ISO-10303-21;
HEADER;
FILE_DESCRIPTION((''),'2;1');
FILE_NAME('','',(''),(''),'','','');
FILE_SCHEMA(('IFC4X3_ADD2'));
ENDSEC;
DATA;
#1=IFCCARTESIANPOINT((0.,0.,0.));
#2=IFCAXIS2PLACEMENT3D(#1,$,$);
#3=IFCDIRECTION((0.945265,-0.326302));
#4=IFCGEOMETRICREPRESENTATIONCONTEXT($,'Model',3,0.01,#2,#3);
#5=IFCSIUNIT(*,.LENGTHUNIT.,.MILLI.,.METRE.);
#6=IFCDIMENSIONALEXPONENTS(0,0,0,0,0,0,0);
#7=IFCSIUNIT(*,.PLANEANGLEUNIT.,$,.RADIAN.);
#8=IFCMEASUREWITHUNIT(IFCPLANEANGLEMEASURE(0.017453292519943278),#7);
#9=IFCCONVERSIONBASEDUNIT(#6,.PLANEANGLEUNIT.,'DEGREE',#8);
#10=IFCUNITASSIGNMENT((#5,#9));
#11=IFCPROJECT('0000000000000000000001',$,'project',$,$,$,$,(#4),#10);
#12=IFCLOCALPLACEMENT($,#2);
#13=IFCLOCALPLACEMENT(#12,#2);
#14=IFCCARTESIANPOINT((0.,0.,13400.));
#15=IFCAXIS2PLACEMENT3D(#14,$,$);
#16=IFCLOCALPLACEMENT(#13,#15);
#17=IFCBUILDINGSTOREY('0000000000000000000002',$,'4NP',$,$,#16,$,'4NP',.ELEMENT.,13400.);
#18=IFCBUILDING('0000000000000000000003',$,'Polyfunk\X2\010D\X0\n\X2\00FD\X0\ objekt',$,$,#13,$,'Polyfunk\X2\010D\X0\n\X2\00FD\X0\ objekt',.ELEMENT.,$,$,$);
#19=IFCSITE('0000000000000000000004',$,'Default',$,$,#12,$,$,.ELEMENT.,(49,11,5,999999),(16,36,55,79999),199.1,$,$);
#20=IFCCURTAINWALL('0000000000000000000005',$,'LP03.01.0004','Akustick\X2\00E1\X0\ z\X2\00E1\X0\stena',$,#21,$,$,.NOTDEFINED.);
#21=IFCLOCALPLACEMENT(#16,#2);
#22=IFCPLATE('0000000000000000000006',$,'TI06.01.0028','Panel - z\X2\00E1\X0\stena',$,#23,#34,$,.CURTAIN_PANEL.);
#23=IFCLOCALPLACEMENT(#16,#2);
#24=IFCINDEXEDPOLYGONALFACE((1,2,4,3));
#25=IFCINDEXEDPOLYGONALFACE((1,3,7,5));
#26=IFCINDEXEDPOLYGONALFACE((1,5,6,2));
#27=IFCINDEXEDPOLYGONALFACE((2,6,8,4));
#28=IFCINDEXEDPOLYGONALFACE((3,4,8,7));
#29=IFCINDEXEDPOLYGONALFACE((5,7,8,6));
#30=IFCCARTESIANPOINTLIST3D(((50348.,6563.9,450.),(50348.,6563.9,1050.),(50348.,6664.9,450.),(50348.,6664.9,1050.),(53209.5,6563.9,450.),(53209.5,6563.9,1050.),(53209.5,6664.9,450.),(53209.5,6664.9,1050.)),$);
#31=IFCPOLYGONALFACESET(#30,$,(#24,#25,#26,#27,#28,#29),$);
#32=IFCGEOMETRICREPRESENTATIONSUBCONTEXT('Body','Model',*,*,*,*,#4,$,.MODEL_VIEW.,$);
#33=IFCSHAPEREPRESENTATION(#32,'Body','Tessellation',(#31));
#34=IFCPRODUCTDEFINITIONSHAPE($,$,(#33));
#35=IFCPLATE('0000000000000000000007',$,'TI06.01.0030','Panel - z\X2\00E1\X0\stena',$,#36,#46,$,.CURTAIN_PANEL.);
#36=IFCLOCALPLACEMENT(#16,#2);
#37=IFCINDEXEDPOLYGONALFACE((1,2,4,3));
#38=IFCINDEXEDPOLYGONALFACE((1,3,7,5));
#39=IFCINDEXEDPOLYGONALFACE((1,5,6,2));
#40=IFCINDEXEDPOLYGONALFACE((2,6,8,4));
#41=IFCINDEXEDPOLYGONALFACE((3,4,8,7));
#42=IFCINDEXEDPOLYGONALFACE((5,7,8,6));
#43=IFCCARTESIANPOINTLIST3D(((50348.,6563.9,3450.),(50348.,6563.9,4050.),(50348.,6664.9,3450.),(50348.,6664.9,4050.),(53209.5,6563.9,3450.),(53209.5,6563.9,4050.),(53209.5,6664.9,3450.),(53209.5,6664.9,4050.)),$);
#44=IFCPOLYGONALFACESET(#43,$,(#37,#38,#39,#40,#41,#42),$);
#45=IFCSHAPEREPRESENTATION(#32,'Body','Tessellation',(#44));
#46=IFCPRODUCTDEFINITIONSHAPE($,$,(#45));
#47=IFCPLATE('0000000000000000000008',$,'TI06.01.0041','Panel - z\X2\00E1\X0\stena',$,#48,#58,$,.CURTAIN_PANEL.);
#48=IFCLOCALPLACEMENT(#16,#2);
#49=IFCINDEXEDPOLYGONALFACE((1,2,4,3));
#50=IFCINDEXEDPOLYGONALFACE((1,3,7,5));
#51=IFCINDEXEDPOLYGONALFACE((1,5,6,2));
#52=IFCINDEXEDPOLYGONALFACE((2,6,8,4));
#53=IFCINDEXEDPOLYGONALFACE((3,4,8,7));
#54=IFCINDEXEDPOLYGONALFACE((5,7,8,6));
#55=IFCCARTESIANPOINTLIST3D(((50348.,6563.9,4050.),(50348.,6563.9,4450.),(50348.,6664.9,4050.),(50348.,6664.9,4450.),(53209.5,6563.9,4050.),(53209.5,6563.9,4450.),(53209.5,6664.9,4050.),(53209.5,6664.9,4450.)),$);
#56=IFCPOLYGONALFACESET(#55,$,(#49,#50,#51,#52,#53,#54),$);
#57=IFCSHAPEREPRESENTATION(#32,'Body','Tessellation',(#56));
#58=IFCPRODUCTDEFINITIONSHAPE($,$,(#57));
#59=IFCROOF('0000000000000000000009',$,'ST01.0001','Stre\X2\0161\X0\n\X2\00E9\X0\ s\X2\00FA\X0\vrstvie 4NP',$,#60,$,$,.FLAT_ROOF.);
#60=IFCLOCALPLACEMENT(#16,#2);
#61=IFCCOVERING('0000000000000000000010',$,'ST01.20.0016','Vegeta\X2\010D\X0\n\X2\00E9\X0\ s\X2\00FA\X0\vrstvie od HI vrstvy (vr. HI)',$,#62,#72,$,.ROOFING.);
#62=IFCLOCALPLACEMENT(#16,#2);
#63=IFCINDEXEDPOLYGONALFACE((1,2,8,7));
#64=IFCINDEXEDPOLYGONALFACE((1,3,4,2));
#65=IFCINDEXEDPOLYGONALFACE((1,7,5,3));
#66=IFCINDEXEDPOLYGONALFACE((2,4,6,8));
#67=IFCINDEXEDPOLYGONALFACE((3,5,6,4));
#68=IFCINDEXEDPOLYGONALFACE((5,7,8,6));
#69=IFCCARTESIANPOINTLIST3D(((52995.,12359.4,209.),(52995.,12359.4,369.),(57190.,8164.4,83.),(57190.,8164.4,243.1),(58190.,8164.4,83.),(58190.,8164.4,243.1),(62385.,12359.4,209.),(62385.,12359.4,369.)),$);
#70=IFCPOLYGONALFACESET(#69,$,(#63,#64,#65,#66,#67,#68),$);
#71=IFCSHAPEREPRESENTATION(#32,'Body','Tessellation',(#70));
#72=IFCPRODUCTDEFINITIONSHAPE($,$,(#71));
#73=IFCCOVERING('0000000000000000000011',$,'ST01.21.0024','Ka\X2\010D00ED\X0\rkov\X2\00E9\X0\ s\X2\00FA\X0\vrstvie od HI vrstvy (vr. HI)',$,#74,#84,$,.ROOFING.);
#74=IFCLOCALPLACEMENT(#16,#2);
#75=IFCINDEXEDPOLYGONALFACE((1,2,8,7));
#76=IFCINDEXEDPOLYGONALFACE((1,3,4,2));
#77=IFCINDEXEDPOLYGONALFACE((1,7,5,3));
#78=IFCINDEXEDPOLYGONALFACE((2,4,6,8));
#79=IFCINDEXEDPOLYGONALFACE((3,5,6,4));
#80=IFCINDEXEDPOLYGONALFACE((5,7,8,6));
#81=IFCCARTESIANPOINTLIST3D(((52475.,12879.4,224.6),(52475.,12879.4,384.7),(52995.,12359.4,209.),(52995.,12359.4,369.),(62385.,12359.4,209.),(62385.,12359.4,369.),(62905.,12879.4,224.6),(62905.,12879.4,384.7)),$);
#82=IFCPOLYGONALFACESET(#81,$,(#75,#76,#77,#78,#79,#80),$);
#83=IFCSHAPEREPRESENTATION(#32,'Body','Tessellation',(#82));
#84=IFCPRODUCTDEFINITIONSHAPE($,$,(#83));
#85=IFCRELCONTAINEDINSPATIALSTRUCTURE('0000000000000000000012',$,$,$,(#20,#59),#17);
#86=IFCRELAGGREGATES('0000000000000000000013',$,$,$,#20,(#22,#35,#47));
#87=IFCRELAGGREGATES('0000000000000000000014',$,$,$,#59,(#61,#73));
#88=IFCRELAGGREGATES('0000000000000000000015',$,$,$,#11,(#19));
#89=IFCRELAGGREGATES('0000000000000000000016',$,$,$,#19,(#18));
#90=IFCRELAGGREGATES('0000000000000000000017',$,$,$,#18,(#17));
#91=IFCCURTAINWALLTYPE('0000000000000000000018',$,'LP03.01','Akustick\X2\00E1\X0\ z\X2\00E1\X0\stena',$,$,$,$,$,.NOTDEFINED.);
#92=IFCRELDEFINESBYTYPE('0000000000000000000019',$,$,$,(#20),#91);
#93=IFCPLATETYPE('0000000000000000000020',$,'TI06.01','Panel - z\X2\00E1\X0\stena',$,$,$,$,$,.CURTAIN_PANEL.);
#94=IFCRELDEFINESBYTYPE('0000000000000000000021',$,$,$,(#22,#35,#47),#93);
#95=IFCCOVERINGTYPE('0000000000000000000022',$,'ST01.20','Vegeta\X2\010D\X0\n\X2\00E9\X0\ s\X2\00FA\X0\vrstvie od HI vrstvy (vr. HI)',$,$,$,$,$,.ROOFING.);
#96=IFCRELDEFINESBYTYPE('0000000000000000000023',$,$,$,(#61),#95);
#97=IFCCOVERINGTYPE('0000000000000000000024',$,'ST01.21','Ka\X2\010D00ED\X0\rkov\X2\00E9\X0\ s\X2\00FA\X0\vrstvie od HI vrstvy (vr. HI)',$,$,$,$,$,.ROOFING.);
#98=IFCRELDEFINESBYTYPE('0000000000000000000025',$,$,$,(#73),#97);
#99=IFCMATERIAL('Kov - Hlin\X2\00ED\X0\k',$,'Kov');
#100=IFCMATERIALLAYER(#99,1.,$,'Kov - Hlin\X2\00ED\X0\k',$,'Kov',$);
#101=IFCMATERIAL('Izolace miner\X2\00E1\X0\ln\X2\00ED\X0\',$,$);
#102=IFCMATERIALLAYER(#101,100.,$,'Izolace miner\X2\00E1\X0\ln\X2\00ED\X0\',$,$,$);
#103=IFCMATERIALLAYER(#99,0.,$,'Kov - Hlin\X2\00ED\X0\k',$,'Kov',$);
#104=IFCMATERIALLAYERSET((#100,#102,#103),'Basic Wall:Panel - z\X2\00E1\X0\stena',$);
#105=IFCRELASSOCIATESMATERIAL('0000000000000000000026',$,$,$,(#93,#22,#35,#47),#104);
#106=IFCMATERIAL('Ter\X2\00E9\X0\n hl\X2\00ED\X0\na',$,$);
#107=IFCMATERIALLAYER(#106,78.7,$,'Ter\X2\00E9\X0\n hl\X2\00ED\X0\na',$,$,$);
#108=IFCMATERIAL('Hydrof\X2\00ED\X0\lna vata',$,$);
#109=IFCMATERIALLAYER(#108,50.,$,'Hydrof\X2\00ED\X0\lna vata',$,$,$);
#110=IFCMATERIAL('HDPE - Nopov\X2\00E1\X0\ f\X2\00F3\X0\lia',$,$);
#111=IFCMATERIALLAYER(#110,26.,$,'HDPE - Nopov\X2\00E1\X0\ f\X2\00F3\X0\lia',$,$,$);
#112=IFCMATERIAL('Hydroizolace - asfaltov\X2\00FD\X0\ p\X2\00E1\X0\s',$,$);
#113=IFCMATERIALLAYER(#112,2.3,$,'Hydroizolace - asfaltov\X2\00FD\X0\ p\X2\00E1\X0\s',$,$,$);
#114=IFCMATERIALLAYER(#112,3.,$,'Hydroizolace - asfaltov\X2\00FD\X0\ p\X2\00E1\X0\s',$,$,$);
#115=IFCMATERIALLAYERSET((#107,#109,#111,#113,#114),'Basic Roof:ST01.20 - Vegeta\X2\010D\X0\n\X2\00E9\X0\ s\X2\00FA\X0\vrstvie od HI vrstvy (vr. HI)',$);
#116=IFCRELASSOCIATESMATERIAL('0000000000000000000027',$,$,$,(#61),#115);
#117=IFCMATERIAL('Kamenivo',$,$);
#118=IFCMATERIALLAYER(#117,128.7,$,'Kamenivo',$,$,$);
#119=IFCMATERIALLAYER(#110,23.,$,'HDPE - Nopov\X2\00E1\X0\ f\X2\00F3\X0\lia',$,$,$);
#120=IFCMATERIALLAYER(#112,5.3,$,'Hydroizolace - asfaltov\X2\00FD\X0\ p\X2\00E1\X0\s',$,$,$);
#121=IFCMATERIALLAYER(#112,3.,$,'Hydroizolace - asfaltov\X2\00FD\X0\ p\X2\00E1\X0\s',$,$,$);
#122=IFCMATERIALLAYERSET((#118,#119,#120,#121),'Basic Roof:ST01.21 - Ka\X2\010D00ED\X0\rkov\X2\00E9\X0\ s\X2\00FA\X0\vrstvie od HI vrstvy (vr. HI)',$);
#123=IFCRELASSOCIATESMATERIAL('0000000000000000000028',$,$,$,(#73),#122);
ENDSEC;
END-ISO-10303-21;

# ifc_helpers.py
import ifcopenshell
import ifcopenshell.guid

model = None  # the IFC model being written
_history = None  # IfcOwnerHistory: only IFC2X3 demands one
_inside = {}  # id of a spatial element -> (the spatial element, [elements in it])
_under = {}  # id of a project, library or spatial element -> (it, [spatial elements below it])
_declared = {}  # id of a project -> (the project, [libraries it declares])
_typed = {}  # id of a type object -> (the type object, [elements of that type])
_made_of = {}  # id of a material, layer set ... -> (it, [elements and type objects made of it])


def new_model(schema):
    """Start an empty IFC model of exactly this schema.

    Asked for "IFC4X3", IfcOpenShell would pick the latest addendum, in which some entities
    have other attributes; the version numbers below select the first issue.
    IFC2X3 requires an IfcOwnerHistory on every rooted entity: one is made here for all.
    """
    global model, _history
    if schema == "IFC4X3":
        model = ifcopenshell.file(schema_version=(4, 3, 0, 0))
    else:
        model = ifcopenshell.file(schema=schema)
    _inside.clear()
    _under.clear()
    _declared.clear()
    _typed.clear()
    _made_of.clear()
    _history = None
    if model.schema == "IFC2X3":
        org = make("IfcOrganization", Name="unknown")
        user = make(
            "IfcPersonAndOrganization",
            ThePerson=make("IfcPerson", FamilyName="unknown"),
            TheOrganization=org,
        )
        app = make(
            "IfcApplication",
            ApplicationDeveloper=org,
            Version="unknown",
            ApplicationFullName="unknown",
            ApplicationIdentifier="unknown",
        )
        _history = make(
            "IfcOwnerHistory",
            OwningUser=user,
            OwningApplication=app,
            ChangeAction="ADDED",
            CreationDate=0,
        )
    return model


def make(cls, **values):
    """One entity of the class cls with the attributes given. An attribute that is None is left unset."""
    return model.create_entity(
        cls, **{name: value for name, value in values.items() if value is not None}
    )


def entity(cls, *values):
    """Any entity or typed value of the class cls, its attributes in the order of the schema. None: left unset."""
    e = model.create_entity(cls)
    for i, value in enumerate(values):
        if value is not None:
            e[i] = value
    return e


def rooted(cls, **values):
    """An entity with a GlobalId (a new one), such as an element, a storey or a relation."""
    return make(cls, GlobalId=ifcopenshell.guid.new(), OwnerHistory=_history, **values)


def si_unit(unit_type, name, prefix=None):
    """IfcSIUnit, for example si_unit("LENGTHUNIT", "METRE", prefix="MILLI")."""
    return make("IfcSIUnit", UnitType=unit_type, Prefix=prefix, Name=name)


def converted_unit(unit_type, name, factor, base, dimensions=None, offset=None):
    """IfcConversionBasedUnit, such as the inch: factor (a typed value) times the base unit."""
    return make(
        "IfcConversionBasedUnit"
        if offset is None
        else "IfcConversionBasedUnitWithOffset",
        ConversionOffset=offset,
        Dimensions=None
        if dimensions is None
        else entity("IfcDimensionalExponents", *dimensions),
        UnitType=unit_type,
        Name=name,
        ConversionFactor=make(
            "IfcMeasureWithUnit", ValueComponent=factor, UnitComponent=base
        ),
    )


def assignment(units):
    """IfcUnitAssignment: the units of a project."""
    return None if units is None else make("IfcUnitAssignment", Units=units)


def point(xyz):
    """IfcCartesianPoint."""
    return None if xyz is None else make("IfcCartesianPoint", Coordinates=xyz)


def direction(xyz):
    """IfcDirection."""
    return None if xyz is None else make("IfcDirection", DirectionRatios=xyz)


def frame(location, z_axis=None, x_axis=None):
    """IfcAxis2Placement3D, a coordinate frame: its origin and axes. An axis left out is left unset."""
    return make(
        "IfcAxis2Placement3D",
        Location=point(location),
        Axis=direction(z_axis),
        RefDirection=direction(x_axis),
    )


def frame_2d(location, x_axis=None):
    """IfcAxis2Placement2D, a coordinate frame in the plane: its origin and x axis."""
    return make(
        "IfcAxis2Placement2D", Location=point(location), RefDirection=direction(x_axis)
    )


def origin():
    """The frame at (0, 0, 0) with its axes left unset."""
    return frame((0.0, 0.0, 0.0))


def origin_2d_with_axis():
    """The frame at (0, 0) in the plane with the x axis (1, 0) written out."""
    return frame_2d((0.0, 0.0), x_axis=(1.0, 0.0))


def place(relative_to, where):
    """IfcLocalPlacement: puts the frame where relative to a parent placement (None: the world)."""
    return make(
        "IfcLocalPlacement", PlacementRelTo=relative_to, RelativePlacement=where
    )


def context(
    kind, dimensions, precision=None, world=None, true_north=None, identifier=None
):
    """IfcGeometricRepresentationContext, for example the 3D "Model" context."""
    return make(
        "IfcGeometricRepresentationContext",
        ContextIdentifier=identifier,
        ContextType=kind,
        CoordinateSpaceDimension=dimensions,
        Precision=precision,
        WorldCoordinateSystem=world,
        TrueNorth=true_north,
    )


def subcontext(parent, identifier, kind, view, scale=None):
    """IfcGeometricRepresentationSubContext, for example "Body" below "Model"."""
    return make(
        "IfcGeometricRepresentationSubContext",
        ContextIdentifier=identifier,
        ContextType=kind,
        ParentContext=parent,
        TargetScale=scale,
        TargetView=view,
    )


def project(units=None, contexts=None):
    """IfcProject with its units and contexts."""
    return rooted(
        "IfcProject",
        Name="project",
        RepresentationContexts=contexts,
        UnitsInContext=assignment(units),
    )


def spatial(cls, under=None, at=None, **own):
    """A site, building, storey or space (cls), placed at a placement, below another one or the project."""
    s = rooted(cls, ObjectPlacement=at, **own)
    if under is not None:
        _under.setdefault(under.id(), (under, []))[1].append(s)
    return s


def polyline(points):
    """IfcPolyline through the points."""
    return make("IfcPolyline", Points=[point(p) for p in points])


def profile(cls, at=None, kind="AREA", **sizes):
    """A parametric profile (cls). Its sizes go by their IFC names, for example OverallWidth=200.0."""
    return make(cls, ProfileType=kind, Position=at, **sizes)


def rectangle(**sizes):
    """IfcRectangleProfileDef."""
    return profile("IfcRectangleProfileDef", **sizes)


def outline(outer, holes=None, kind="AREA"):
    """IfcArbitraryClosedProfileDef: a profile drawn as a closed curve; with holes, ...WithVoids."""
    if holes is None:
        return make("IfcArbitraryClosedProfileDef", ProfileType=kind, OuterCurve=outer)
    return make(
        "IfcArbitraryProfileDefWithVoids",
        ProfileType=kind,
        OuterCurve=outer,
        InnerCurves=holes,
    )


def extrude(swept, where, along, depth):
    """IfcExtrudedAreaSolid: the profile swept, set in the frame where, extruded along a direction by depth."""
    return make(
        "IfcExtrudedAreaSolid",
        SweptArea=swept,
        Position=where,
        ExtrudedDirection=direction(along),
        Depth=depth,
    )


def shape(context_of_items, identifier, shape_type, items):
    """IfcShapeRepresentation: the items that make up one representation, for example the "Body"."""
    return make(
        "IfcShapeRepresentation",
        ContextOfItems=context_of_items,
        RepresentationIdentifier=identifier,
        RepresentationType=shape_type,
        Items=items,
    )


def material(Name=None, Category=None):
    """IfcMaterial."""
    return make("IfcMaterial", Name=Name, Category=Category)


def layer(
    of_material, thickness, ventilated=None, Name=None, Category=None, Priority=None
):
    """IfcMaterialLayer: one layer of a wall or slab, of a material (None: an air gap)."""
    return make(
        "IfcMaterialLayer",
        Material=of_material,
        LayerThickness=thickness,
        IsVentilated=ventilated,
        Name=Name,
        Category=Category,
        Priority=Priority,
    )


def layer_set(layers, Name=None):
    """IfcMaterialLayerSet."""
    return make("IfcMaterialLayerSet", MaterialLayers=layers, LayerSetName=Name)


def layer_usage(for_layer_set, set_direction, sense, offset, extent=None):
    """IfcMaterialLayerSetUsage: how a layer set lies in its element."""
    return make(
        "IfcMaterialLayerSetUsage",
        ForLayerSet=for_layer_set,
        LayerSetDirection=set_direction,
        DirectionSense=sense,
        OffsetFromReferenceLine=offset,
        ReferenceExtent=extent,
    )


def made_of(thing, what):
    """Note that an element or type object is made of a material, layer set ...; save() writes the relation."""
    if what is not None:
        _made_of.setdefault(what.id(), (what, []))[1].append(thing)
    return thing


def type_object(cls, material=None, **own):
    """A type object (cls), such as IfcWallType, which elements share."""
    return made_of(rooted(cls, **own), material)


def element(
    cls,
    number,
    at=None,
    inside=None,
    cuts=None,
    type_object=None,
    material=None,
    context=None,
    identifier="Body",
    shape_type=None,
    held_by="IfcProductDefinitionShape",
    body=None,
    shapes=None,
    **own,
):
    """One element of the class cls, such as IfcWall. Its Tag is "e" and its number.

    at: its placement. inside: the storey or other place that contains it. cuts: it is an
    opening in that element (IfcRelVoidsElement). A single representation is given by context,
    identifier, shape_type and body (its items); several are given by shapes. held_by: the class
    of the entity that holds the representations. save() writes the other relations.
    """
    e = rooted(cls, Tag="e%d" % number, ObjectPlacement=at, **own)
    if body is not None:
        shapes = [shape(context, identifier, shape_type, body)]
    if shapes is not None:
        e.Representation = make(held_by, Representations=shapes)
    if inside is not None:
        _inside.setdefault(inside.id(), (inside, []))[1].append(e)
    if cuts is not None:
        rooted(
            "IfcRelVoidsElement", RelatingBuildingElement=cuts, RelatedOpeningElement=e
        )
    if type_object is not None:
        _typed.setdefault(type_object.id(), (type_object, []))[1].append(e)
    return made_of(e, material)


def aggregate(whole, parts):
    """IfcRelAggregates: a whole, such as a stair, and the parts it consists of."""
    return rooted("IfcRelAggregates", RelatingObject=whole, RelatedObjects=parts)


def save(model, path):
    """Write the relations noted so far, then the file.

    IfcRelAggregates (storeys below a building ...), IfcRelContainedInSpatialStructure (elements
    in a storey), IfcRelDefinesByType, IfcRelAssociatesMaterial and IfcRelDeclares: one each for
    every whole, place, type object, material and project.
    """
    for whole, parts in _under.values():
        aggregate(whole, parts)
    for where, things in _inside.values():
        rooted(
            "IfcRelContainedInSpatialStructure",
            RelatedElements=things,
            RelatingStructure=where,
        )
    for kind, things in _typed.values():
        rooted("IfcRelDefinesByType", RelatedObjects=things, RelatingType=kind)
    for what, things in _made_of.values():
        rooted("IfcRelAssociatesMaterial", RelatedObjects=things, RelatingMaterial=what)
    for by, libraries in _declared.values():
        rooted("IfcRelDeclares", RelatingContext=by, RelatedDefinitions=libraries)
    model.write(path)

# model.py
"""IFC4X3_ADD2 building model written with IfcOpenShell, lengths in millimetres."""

from ifc_helpers import new_model, entity, si_unit, converted_unit, direction, frame, frame_2d, origin, origin_2d_with_axis, place, context, subcontext, project, spatial, polyline, rectangle, outline, extrude, material, layer, layer_set, layer_usage, type_object, element, aggregate, save


model = new_model("IFC4X3_ADD2")

# Units and contexts
model_context = context("Model", 3, precision=0.01, world=origin(), true_north=direction((0.945265, -0.326302)))
body_context = subcontext(model_context, "Body", "Model", "MODEL_VIEW")
ifc_project = project(units=[si_unit("LENGTHUNIT", "METRE", prefix="MILLI"), converted_unit("PLANEANGLEUNIT", "DEGREE", entity("IfcPlaneAngleMeasure", 0.017453292519943278), si_unit("PLANEANGLEUNIT", "RADIAN"), dimensions=[0, 0, 0, 0, 0, 0, 0])], contexts=[model_context])

# Site, building, storey
site_placement = place(None, origin())
site = spatial("IfcSite", under=ifc_project, at=site_placement, Name="Default", CompositionType="ELEMENT", RefLatitude=(49, 11, 5, 999999), RefLongitude=(16, 36, 55, 79999), RefElevation=199.1)
building_placement = place(site_placement, origin())
building = spatial("IfcBuilding", under=site, at=building_placement, Name="Polyfunkčný objekt", LongName="Polyfunkčný objekt", CompositionType="ELEMENT")
storey_placement = place(building_placement, frame((0.0, 0.0, 13400.0)))
storey = spatial("IfcBuildingStorey", under=building, at=storey_placement, Name="4NP", LongName="4NP", CompositionType="ELEMENT", Elevation=13400.0)

# Curtain wall
curtain_wall_type = type_object("IfcCurtainWallType", Name="LP03.01", Description="Akustická zástena", PredefinedType="NOTDEFINED")
curtain_wall_1_placement = place(storey_placement, frame((0.0, 0.0, -13400.0)))
curtain_wall_1 = element("IfcCurtainWall", 1, at=curtain_wall_1_placement, inside=storey, type_object=curtain_wall_type, Name="LP03.01.0004", Description="Akustická zástena", PredefinedType="NOTDEFINED")

# Plates
ifc_material_1 = material(Name="Kov - Hliník", Category="Kov")
ifc_layer_1 = layer(ifc_material_1, 1.0, Name="Kov - Hliník", Category="Kov")
ifc_material_2 = material(Name="Izolace minerální")
ifc_layer_2 = layer(ifc_material_2, 100.0, Name="Izolace minerální")
ifc_layer_3 = layer(ifc_material_1, 0.0, Name="Kov - Hliník", Category="Kov")
ifc_layer_set_1 = layer_set([ifc_layer_1, ifc_layer_2, ifc_layer_3], Name="Basic Wall:Panel - zástena")
ifc_layer_usage_1 = layer_usage(ifc_layer_set_1, "AXIS2", "POSITIVE", -50.5)
plate_type = type_object("IfcPlateType", Name="TI06.01", Description="Panel - zástena", PredefinedType="CURTAIN_PANEL", material=ifc_layer_set_1)
plate_1_placement = place(storey_placement, frame((50348.0, 6614.4, 450.0)))
plate_1 = element("IfcPlate", 2, at=plate_1_placement, type_object=plate_type, material=ifc_layer_usage_1, Name="TI06.01.0028", Description="Panel - zástena", PredefinedType="CURTAIN_PANEL", context=body_context, shape_type="SweptSolid", body=[
    extrude(rectangle(XDim=101.0, YDim=2861.5, at=frame_2d((0.0, 0.0), x_axis=(1.0, 0.0))), frame((1430.7, 0.0, 0.0), z_axis=(0.0, 0.0, 1.0), x_axis=(0.0, 1.0, 0.0)), (0.0, 0.0, 1.0), 600.0),
])
ifc_layer_usage_2 = layer_usage(ifc_layer_set_1, "AXIS2", "POSITIVE", -50.5)
plate_2_placement = place(storey_placement, frame((50348.0, 6614.4, 3450.0)))
plate_2 = element("IfcPlate", 3, at=plate_2_placement, type_object=plate_type, material=ifc_layer_usage_2, Name="TI06.01.0030", Description="Panel - zástena", PredefinedType="CURTAIN_PANEL", context=body_context, shape_type="SweptSolid", body=[
    extrude(rectangle(XDim=101.0, YDim=2861.5, at=frame_2d((0.0, 0.0), x_axis=(1.0, 0.0))), frame((1430.7, 0.0, 0.0), z_axis=(0.0, 0.0, 1.0), x_axis=(0.0, 1.0, 0.0)), (0.0, 0.0, 1.0), 600.0),
])
ifc_layer_usage_3 = layer_usage(ifc_layer_set_1, "AXIS2", "POSITIVE", -50.5)
plate_3_placement = place(storey_placement, frame((50348.0, 6614.4, 4050.0)))
plate_3 = element("IfcPlate", 4, at=plate_3_placement, type_object=plate_type, material=ifc_layer_usage_3, Name="TI06.01.0041", Description="Panel - zástena", PredefinedType="CURTAIN_PANEL", context=body_context, shape_type="SweptSolid", body=[
    extrude(rectangle(XDim=101.0, YDim=2861.5, at=origin_2d_with_axis()), frame((1430.7, 0.0, 0.0), z_axis=(0.0, 0.0, 1.0), x_axis=(0.0, 1.0, 0.0)), (0.0, 0.0, 1.0), 400.0),
])
aggregate(curtain_wall_1, [plate_1, plate_2, plate_3])

# Roof, coverings
roof = element("IfcRoof", 5, inside=storey, Name="ST01.0001", Description="Strešné súvrstvie 4NP", PredefinedType="FLAT_ROOF")
ifc_material_3 = material(Name="Terén hlína")
ifc_layer_4 = layer(ifc_material_3, 78.7, Name="Terén hlína")
ifc_material_4 = material(Name="Hydrofílna vata")
ifc_layer_5 = layer(ifc_material_4, 50.0, Name="Hydrofílna vata")
ifc_material_5 = material(Name="HDPE - Nopová fólia")
ifc_layer_6 = layer(ifc_material_5, 26.0, Name="HDPE - Nopová fólia")
ifc_material_6 = material(Name="Hydroizolace - asfaltový pás")
ifc_layer_7 = layer(ifc_material_6, 2.3, Name="Hydroizolace - asfaltový pás")
ifc_layer_8 = layer(ifc_material_6, 3.0, Name="Hydroizolace - asfaltový pás")
ifc_layer_set_2 = layer_set([ifc_layer_4, ifc_layer_5, ifc_layer_6, ifc_layer_7, ifc_layer_8], Name="Basic Roof:ST01.20 - Vegetačné súvrstvie od HI vrstvy (vr. HI)")
covering_type_1 = type_object("IfcCoveringType", Name="ST01.20", Description="Vegetačné súvrstvie od HI vrstvy (vr. HI)", PredefinedType="ROOFING")
placement_1 = place(storey_placement, frame((52995.0, 8164.4, 83.0)))
covering_1_placement = place(placement_1, origin())
covering_1 = element("IfcCovering", 6, at=covering_1_placement, type_object=covering_type_1, material=ifc_layer_set_2, Name="ST01.20.0016", Description="Vegetačné súvrstvie od HI vrstvy (vr. HI)", PredefinedType="ROOFING", context=body_context, shape_type="SweptSolid", body=[
    extrude(outline(polyline([(500.0, -2098.4), (4695.0, 2098.4), (-4695.0, 2098.4), (-500.0, -2098.4), (500.0, -2098.4)])), frame((4695.0, 2097.5, 63.0), z_axis=(0.0, -0.030015, 0.999549), x_axis=(1.0, 0.0, 0.0)), (0.0, 0.030015, 0.999549), 160.1),
])
ifc_material_7 = material(Name="Kamenivo")
ifc_layer_9 = layer(ifc_material_7, 128.7, Name="Kamenivo")
ifc_layer_10 = layer(ifc_material_5, 23.0, Name="HDPE - Nopová fólia")
ifc_layer_11 = layer(ifc_material_6, 5.3, Name="Hydroizolace - asfaltový pás")
ifc_layer_12 = layer(ifc_material_6, 3.0, Name="Hydroizolace - asfaltový pás")
ifc_layer_set_3 = layer_set([ifc_layer_9, ifc_layer_10, ifc_layer_11, ifc_layer_12], Name="Basic Roof:ST01.21 - Kačírkové súvrstvie od HI vrstvy (vr. HI)")
covering_type_2 = type_object("IfcCoveringType", Name="ST01.21", Description="Kačírkové súvrstvie od HI vrstvy (vr. HI)", PredefinedType="ROOFING")
placement_2 = place(storey_placement, frame((52475.0, 12359.4, 209.0)))
covering_2_placement = place(placement_2, origin())
covering_2 = element("IfcCovering", 7, at=covering_2_placement, type_object=covering_type_2, material=ifc_layer_set_3, Name="ST01.21.0024", Description="Kačírkové súvrstvie od HI vrstvy (vr. HI)", PredefinedType="ROOFING", context=body_context, shape_type="SweptSolid", body=[
    extrude(outline(polyline([(4695.0, -260.1), (5215.0, 260.1), (-5215.0, 260.1), (-4695.0, -260.1), (4695.0, -260.1)])), frame((5215.0, 260.0, 7.8), z_axis=(0.0, -0.030015, 0.999549), x_axis=(1.0, 0.0, 0.0)), (0.0, 0.030015, 0.999549), 160.1),
])
aggregate(roof, [covering_1, covering_2])

save(model, "model.ifc")
